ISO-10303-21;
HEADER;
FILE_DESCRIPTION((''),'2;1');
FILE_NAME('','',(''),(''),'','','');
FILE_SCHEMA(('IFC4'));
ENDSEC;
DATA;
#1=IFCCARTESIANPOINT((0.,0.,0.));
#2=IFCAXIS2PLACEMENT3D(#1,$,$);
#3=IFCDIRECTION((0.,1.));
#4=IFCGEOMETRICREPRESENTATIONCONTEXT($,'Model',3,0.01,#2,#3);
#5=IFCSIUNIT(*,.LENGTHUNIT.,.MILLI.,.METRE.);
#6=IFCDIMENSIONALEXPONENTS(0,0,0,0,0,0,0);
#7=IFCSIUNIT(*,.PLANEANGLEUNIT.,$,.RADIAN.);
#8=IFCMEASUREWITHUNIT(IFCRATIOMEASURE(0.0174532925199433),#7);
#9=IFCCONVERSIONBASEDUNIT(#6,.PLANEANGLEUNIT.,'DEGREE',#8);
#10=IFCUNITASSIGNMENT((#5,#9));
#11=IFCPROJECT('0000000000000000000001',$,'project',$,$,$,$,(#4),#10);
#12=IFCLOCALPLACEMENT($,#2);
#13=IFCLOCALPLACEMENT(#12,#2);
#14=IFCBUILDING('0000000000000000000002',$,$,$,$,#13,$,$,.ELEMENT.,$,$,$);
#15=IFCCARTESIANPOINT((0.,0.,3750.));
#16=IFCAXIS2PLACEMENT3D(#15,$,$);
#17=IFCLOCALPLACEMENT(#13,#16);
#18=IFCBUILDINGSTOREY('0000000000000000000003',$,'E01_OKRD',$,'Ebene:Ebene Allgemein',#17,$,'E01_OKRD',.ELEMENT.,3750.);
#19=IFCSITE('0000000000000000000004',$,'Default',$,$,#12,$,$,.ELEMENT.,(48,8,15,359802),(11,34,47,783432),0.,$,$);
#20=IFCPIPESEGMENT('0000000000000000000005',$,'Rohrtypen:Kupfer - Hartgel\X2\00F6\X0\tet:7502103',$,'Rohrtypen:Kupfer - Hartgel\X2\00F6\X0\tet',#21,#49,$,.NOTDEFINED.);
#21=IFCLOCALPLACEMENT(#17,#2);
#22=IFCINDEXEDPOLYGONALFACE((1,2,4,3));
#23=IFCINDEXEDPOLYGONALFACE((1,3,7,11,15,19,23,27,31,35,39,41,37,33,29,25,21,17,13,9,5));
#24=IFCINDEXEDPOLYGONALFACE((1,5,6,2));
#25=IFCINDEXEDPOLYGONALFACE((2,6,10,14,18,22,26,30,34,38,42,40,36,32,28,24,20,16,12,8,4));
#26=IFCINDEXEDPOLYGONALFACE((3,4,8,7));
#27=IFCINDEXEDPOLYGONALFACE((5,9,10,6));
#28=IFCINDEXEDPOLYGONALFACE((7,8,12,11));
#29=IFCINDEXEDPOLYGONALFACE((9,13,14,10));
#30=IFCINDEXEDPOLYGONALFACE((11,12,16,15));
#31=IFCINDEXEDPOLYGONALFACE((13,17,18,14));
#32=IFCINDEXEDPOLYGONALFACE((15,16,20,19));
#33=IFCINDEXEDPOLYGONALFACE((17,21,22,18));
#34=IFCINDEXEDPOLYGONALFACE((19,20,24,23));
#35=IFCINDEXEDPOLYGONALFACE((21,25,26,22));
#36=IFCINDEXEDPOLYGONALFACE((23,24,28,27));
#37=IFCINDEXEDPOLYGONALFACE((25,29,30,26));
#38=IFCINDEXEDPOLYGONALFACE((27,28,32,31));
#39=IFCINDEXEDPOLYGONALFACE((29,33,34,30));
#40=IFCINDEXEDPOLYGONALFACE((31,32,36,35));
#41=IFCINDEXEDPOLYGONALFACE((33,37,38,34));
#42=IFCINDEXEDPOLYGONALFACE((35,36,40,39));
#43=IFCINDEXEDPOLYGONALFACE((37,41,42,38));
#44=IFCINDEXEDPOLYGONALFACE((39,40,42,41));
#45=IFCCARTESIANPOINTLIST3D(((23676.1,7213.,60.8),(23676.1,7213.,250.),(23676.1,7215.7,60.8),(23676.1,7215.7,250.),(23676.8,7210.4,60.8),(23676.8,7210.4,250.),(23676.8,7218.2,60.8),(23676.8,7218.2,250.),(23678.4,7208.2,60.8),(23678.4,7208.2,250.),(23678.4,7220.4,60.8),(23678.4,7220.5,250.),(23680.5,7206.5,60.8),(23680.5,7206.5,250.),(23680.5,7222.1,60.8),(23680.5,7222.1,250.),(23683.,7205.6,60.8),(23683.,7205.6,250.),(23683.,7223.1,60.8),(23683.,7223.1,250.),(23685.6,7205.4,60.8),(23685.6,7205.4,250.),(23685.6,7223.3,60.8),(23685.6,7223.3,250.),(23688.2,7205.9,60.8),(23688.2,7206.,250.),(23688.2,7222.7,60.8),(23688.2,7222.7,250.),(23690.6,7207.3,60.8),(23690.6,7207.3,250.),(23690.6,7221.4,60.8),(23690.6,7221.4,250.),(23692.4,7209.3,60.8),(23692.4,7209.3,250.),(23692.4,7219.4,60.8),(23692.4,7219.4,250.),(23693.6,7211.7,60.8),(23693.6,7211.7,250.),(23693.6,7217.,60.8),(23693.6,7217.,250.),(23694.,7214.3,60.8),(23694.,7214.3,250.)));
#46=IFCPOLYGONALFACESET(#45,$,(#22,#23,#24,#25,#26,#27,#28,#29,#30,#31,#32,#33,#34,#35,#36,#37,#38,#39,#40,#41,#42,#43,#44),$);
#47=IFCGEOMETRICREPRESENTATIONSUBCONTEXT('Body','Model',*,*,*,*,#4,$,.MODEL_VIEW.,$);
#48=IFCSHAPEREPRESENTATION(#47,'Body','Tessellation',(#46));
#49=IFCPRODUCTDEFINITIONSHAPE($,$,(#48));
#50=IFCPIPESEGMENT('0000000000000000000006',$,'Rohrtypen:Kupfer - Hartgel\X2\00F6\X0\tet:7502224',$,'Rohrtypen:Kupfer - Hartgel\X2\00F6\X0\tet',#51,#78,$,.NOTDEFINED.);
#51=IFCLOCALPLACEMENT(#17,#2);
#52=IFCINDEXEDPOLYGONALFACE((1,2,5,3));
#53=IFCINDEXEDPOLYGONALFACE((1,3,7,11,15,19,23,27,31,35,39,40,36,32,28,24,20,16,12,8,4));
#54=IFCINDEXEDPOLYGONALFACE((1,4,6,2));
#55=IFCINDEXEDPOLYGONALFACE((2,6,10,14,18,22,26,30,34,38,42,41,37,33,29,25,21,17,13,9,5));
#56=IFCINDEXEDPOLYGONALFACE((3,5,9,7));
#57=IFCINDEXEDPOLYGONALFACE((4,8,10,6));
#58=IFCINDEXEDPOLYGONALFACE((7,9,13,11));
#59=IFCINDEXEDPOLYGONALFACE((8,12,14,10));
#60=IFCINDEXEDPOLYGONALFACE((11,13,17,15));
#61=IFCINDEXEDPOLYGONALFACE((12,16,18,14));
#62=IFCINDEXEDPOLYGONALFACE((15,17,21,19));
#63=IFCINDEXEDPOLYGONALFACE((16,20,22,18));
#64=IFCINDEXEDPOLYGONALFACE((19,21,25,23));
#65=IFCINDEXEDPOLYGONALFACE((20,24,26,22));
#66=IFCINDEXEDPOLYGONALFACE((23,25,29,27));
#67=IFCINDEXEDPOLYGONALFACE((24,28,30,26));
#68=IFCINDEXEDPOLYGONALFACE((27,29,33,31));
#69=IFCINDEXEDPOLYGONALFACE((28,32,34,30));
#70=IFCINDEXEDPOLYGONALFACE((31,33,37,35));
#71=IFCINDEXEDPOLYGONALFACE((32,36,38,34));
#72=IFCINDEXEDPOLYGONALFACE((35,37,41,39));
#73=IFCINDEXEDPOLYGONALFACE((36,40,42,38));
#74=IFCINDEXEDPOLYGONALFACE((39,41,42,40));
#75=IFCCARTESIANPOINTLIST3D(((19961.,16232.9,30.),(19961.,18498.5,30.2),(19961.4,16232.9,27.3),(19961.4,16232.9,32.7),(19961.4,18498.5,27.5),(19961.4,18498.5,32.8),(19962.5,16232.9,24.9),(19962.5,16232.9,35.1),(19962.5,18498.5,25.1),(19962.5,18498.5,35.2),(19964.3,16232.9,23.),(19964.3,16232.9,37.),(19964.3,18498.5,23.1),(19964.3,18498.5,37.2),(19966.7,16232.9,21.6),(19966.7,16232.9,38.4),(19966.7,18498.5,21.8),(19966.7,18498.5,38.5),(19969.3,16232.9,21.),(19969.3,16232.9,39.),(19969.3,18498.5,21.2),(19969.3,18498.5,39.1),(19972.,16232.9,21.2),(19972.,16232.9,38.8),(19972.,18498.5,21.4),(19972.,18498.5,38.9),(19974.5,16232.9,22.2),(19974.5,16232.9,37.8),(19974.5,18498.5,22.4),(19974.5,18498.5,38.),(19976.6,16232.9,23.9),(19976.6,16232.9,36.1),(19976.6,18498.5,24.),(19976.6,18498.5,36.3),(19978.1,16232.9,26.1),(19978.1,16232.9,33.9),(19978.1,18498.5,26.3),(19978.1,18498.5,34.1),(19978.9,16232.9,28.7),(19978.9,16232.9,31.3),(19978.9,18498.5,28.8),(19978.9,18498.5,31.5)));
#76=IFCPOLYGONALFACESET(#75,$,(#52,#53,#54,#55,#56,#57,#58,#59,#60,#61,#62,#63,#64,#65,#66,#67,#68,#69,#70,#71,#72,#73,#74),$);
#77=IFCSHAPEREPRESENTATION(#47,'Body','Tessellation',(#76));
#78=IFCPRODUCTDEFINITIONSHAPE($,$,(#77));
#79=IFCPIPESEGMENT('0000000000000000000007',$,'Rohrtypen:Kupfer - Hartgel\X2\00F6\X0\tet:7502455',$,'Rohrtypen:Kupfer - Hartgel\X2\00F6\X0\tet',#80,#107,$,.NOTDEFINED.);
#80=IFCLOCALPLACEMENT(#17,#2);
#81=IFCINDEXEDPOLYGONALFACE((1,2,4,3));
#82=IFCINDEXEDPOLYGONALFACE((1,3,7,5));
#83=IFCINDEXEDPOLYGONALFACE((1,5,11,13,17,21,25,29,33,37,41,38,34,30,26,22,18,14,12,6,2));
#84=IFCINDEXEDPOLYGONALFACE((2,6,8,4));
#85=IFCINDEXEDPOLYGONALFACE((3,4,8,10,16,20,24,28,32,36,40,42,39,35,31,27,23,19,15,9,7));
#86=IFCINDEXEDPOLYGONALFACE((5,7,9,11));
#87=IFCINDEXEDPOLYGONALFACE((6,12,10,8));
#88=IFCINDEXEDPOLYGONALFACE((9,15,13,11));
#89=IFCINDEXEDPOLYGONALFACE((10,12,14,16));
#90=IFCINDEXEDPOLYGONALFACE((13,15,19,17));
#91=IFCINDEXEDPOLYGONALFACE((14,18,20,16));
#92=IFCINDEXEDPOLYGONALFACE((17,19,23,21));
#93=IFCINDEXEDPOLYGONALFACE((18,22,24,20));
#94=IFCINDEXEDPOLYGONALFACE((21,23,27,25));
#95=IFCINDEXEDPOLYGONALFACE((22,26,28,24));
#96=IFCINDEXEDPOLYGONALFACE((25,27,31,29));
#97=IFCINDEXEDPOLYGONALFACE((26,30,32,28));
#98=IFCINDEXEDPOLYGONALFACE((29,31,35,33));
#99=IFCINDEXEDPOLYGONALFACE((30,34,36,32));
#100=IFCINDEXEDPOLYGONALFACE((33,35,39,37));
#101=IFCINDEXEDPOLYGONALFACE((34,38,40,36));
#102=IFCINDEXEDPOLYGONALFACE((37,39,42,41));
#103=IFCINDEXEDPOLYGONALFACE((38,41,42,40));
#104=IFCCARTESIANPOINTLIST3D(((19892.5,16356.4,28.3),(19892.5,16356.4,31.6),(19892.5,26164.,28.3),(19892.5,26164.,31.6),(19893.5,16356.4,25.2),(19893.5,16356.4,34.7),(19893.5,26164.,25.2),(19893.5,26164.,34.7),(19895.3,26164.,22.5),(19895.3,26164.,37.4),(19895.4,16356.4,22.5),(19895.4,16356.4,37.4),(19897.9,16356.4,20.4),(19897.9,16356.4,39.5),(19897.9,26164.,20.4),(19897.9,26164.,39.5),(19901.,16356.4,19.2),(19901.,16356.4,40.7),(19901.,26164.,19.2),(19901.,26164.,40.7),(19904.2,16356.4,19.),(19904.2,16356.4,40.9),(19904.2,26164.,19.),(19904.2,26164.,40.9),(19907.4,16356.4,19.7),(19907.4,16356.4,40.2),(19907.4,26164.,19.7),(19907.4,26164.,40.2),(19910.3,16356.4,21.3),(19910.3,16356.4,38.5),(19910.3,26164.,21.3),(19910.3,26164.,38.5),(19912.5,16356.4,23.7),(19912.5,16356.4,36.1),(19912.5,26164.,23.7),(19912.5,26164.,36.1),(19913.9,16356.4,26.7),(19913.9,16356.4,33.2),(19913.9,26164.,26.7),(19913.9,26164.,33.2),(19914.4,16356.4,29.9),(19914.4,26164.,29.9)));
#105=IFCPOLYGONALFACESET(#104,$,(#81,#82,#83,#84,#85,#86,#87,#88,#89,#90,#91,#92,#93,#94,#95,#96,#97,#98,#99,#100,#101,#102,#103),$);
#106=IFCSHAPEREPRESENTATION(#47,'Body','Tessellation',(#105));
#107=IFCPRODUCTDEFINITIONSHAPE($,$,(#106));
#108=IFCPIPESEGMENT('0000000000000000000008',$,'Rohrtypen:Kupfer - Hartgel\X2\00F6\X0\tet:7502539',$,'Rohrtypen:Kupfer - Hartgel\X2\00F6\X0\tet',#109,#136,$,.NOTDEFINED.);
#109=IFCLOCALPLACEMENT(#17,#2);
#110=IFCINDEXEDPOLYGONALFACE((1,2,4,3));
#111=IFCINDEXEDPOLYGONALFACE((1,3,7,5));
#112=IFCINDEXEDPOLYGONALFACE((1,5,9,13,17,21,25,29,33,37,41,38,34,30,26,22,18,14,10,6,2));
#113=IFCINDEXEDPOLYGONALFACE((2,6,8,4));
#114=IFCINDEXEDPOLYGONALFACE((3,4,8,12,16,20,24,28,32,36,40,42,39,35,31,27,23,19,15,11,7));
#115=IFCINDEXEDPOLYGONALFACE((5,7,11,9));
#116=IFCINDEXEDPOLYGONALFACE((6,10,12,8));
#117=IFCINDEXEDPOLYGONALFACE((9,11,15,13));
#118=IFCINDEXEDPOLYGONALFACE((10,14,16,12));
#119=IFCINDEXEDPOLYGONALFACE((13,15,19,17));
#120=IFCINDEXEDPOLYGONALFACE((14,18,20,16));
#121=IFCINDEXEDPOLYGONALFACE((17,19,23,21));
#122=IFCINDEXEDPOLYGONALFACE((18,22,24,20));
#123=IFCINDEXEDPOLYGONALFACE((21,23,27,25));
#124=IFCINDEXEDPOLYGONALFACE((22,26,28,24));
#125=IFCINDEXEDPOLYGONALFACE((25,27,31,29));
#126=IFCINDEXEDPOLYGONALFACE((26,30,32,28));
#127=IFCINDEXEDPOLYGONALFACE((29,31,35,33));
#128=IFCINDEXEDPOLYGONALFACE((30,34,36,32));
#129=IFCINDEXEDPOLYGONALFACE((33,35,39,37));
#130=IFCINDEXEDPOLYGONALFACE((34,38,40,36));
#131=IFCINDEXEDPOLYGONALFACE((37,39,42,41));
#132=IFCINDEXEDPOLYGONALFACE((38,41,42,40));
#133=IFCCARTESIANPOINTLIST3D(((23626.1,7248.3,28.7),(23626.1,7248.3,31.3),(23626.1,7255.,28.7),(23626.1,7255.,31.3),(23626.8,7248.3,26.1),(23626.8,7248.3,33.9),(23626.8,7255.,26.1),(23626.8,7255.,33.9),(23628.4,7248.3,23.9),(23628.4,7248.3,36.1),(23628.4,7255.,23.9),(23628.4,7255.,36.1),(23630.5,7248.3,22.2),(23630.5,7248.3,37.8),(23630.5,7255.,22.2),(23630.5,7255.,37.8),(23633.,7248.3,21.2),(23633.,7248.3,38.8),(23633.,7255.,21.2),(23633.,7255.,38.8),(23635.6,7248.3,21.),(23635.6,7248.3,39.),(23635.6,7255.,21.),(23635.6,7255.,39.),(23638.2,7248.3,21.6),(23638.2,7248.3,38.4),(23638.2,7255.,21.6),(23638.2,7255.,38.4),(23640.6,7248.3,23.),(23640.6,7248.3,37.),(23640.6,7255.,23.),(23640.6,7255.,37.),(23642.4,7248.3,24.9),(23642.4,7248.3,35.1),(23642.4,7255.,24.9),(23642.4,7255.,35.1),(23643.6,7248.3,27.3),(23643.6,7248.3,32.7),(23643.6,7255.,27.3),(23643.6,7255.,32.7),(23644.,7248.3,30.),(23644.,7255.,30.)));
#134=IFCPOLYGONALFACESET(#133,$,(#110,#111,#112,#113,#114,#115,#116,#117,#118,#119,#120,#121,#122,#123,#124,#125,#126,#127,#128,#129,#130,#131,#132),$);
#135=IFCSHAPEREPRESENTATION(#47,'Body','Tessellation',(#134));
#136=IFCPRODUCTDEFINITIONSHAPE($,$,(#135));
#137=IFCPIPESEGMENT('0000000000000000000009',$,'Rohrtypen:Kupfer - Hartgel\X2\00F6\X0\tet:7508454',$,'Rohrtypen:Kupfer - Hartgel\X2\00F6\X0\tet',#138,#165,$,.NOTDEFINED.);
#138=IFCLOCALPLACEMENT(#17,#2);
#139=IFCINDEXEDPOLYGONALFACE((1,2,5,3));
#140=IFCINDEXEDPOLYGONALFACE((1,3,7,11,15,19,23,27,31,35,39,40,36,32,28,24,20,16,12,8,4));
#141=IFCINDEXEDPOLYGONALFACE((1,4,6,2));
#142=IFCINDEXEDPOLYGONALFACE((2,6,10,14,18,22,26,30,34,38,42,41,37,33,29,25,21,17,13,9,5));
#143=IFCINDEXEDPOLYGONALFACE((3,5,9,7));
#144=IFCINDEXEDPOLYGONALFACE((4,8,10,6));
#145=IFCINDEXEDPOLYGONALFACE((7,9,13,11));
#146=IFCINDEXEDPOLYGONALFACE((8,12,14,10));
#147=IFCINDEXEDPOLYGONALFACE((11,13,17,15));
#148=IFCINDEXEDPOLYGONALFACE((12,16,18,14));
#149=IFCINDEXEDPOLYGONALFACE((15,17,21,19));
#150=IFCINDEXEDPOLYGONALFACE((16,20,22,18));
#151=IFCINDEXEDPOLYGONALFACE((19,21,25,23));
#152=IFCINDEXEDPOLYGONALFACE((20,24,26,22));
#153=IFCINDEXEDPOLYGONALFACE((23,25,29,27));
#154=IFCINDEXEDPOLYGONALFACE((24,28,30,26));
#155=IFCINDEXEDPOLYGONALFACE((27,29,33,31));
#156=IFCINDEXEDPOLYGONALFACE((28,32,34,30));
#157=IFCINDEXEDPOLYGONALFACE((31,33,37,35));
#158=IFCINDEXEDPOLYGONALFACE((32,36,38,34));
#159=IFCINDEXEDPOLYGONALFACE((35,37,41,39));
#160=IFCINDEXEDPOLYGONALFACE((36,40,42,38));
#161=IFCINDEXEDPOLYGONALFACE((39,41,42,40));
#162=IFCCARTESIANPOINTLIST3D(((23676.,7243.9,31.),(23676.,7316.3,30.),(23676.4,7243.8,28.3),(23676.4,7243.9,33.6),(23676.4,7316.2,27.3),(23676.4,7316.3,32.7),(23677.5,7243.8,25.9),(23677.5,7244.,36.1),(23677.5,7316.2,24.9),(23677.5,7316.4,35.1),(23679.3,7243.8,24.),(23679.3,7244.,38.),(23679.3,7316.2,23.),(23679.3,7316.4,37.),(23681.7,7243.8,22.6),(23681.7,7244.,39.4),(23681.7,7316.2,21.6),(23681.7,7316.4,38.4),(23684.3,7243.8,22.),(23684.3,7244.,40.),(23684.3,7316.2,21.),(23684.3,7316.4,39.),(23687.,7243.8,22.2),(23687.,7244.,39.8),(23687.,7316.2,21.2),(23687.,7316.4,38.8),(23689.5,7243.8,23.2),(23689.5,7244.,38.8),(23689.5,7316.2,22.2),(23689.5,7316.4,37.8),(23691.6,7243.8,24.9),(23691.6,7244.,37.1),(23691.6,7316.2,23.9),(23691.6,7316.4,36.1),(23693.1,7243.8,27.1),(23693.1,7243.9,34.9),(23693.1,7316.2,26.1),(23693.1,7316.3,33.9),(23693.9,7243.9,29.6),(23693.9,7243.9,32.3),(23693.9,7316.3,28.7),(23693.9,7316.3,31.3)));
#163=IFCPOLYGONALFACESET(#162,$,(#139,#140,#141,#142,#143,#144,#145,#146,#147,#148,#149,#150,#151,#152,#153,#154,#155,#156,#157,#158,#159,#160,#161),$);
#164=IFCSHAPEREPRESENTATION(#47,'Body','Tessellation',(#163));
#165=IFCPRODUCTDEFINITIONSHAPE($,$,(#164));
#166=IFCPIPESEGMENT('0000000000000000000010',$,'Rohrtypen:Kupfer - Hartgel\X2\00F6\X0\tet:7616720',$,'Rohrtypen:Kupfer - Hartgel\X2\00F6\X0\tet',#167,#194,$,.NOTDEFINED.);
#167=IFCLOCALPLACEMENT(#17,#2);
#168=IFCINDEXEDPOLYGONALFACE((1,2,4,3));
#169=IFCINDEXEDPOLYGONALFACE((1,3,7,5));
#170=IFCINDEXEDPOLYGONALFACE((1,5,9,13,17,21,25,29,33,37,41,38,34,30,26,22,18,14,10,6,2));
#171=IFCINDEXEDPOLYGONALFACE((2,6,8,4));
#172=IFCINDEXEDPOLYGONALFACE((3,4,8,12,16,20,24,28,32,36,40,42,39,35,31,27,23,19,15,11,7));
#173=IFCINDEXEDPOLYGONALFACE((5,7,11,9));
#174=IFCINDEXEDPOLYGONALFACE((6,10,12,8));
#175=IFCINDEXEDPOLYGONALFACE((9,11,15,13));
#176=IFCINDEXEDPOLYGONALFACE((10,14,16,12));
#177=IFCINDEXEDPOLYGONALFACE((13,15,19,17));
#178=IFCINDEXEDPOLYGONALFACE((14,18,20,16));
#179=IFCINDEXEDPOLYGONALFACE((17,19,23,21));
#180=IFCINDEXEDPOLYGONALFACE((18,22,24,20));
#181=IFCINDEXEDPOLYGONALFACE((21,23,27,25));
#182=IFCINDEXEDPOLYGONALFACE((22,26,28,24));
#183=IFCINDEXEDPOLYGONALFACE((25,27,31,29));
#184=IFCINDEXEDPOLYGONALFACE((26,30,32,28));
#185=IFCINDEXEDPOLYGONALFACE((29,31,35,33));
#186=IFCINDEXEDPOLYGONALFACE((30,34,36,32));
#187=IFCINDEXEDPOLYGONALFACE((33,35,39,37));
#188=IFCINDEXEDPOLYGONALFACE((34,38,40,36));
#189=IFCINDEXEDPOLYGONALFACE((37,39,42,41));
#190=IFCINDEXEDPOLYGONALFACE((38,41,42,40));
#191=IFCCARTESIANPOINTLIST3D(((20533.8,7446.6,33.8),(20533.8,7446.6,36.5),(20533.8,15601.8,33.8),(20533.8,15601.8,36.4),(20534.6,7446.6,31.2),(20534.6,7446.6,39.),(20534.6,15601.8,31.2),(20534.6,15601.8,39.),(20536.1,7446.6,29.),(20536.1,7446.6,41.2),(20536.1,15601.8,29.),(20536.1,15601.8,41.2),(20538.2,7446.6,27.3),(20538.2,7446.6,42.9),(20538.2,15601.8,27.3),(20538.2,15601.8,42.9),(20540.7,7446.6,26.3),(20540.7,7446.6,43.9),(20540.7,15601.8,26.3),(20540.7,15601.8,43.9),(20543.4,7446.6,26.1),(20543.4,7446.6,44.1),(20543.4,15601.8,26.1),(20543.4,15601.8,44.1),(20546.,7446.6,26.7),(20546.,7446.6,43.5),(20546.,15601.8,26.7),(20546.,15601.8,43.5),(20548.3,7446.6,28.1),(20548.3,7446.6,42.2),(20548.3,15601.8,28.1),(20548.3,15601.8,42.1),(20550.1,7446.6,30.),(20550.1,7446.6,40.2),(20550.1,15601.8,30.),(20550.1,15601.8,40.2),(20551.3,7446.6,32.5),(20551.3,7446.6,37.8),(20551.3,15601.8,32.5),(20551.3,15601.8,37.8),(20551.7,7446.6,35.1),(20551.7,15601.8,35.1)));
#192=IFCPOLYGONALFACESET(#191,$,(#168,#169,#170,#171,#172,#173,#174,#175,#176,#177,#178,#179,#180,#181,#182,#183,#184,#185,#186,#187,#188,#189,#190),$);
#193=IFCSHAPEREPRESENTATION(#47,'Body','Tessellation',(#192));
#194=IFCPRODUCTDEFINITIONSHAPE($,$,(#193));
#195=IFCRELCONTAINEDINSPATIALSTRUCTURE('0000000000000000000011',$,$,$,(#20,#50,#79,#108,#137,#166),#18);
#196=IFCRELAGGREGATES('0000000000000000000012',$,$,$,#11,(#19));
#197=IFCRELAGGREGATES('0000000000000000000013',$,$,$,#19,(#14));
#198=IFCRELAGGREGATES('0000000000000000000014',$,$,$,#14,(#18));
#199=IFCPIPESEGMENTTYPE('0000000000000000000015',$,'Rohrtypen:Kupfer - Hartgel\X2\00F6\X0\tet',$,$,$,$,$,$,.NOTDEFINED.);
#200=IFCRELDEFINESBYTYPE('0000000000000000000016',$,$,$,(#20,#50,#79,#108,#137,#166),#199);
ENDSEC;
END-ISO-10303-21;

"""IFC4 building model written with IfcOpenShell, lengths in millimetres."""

from ifc_helpers import new_model, entity, si_unit, converted_unit, direction, frame, frame_2d, origin, origin_2d_with_axis, place, context, subcontext, project, spatial, circle, extrude, type_object, element, save


model = new_model("IFC4")

# Units and contexts
model_context = context("Model", 3, precision=0.01, world=origin(), true_north=direction((0.0, 1.0)))
body_context = subcontext(model_context, "Body", "Model", "MODEL_VIEW")
ifc_project = project(units=[si_unit("LENGTHUNIT", "METRE", prefix="MILLI"), converted_unit("PLANEANGLEUNIT", "DEGREE", entity("IfcRatioMeasure", 0.0174532925199433), si_unit("PLANEANGLEUNIT", "RADIAN"), dimensions=[0, 0, 0, 0, 0, 0, 0])], contexts=[model_context])

# Site, building, storey
site_placement = place(None, origin())
site = spatial("IfcSite", under=ifc_project, at=site_placement, Name="Default", CompositionType="ELEMENT", RefLatitude=(48, 8, 15, 359802), RefLongitude=(11, 34, 47, 783432), RefElevation=0.0)
building_placement = place(site_placement, origin())
building = spatial("IfcBuilding", under=site, at=building_placement, CompositionType="ELEMENT")
storey_placement = place(building_placement, frame((0.0, 0.0, 3750.0)))
storey = spatial("IfcBuildingStorey", under=building, at=storey_placement, Name="E01_OKRD", ObjectType="Ebene:Ebene Allgemein", LongName="E01_OKRD", CompositionType="ELEMENT", Elevation=3750.0)

# Pipe segments
pipe_segment_type = type_object("IfcPipeSegmentType", Name="Rohrtypen:Kupfer - Hartgelötet", PredefinedType="NOTDEFINED")
pipe_segment_1_placement = place(storey_placement, frame((23674.4, 7203.7, 60.8)))
element("IfcPipeSegment", 1, at=pipe_segment_1_placement, inside=storey, type_object=pipe_segment_type, Name="Rohrtypen:Kupfer - Hartgelötet:7502103", ObjectType="Rohrtypen:Kupfer - Hartgelötet", PredefinedType="NOTDEFINED", context=body_context, shape_type="SweptSolid", body=[
    extrude(circle(Radius=9.0, at=origin_2d_with_axis()), frame((10.6, 10.6, 0.0), z_axis=(0.0, 0.00007, 1.0), x_axis=(1.0, 0.0, 0.0)), (0.0, 0.0, 1.0), 189.2),
])
pipe_segment_2_placement = place(storey_placement, frame((19959.4, 16232.9, 19.4)))
element("IfcPipeSegment", 2, at=pipe_segment_2_placement, inside=storey, type_object=pipe_segment_type, Name="Rohrtypen:Kupfer - Hartgelötet:7502224", ObjectType="Rohrtypen:Kupfer - Hartgelötet", PredefinedType="NOTDEFINED", context=body_context, shape_type="SweptSolid", body=[
    extrude(circle(Radius=9.0, at=frame_2d((0.0, 0.0), x_axis=(1.0, 0.0))), frame((10.6, 0.0, 10.6), z_axis=(0.0, 1.0, 0.000072), x_axis=(-1.0, 0.0, 0.0)), (0.0, 0.0, 1.0), 2265.6),
])
pipe_segment_3_placement = place(storey_placement, frame((19890.8, 16356.4, 17.3)))
element("IfcPipeSegment", 3, at=pipe_segment_3_placement, inside=storey, type_object=pipe_segment_type, Name="Rohrtypen:Kupfer - Hartgelötet:7502455", ObjectType="Rohrtypen:Kupfer - Hartgelötet", PredefinedType="NOTDEFINED", context=body_context, shape_type="SweptSolid", body=[
    extrude(circle(Radius=11.0, at=origin_2d_with_axis()), frame((12.6, 0.0, 12.6), z_axis=(0.0, 1.0, 0.0), x_axis=(1.0, 0.0, 0.0)), (0.0, 0.0, 1.0), 9807.6),
])
pipe_segment_4_placement = place(storey_placement, frame((23624.4, 7248.3, 19.4)))
element("IfcPipeSegment", 4, at=pipe_segment_4_placement, inside=storey, type_object=pipe_segment_type, Name="Rohrtypen:Kupfer - Hartgelötet:7502539", ObjectType="Rohrtypen:Kupfer - Hartgelötet", PredefinedType="NOTDEFINED", context=body_context, shape_type="SweptSolid", body=[
    extrude(circle(Radius=9.0, at=origin_2d_with_axis()), frame((10.6, 0.0, 10.6), z_axis=(0.000051, 1.0, 0.0), x_axis=(1.0, -0.000051, 0.0)), (0.0, 0.0, 1.0), 6.6),
])
pipe_segment_5_placement = place(storey_placement, frame((23674.4, 7243.8, 19.4)))
element("IfcPipeSegment", 5, at=pipe_segment_5_placement, inside=storey, type_object=pipe_segment_type, Name="Rohrtypen:Kupfer - Hartgelötet:7508454", ObjectType="Rohrtypen:Kupfer - Hartgelötet", PredefinedType="NOTDEFINED", context=body_context, shape_type="SweptSolid", body=[
    extrude(circle(Radius=9.0, at=origin_2d_with_axis()), frame((10.6, 72.5, 10.6), z_axis=(0.0, -0.999906, 0.013687), x_axis=(-1.0, 0.0, 0.0)), (0.0, 0.0, 1.0), 72.4),
])
pipe_segment_6_placement = place(storey_placement, frame((20532.1, 7446.6, 24.5)))
element("IfcPipeSegment", 6, at=pipe_segment_6_placement, inside=storey, type_object=pipe_segment_type, Name="Rohrtypen:Kupfer - Hartgelötet:7616720", ObjectType="Rohrtypen:Kupfer - Hartgelötet", PredefinedType="NOTDEFINED", context=body_context, shape_type="SweptSolid", body=[
    extrude(circle(Radius=9.0, at=frame_2d((0.0, 0.0), x_axis=(1.0, 0.0))), frame((10.6, 0.0, 10.6), z_axis=(0.0, 1.0, -0.000002), x_axis=(1.0, 0.0, 0.0)), (0.0, 0.0, 1.0), 8155.2),
])

save(model, "model.ifc")
